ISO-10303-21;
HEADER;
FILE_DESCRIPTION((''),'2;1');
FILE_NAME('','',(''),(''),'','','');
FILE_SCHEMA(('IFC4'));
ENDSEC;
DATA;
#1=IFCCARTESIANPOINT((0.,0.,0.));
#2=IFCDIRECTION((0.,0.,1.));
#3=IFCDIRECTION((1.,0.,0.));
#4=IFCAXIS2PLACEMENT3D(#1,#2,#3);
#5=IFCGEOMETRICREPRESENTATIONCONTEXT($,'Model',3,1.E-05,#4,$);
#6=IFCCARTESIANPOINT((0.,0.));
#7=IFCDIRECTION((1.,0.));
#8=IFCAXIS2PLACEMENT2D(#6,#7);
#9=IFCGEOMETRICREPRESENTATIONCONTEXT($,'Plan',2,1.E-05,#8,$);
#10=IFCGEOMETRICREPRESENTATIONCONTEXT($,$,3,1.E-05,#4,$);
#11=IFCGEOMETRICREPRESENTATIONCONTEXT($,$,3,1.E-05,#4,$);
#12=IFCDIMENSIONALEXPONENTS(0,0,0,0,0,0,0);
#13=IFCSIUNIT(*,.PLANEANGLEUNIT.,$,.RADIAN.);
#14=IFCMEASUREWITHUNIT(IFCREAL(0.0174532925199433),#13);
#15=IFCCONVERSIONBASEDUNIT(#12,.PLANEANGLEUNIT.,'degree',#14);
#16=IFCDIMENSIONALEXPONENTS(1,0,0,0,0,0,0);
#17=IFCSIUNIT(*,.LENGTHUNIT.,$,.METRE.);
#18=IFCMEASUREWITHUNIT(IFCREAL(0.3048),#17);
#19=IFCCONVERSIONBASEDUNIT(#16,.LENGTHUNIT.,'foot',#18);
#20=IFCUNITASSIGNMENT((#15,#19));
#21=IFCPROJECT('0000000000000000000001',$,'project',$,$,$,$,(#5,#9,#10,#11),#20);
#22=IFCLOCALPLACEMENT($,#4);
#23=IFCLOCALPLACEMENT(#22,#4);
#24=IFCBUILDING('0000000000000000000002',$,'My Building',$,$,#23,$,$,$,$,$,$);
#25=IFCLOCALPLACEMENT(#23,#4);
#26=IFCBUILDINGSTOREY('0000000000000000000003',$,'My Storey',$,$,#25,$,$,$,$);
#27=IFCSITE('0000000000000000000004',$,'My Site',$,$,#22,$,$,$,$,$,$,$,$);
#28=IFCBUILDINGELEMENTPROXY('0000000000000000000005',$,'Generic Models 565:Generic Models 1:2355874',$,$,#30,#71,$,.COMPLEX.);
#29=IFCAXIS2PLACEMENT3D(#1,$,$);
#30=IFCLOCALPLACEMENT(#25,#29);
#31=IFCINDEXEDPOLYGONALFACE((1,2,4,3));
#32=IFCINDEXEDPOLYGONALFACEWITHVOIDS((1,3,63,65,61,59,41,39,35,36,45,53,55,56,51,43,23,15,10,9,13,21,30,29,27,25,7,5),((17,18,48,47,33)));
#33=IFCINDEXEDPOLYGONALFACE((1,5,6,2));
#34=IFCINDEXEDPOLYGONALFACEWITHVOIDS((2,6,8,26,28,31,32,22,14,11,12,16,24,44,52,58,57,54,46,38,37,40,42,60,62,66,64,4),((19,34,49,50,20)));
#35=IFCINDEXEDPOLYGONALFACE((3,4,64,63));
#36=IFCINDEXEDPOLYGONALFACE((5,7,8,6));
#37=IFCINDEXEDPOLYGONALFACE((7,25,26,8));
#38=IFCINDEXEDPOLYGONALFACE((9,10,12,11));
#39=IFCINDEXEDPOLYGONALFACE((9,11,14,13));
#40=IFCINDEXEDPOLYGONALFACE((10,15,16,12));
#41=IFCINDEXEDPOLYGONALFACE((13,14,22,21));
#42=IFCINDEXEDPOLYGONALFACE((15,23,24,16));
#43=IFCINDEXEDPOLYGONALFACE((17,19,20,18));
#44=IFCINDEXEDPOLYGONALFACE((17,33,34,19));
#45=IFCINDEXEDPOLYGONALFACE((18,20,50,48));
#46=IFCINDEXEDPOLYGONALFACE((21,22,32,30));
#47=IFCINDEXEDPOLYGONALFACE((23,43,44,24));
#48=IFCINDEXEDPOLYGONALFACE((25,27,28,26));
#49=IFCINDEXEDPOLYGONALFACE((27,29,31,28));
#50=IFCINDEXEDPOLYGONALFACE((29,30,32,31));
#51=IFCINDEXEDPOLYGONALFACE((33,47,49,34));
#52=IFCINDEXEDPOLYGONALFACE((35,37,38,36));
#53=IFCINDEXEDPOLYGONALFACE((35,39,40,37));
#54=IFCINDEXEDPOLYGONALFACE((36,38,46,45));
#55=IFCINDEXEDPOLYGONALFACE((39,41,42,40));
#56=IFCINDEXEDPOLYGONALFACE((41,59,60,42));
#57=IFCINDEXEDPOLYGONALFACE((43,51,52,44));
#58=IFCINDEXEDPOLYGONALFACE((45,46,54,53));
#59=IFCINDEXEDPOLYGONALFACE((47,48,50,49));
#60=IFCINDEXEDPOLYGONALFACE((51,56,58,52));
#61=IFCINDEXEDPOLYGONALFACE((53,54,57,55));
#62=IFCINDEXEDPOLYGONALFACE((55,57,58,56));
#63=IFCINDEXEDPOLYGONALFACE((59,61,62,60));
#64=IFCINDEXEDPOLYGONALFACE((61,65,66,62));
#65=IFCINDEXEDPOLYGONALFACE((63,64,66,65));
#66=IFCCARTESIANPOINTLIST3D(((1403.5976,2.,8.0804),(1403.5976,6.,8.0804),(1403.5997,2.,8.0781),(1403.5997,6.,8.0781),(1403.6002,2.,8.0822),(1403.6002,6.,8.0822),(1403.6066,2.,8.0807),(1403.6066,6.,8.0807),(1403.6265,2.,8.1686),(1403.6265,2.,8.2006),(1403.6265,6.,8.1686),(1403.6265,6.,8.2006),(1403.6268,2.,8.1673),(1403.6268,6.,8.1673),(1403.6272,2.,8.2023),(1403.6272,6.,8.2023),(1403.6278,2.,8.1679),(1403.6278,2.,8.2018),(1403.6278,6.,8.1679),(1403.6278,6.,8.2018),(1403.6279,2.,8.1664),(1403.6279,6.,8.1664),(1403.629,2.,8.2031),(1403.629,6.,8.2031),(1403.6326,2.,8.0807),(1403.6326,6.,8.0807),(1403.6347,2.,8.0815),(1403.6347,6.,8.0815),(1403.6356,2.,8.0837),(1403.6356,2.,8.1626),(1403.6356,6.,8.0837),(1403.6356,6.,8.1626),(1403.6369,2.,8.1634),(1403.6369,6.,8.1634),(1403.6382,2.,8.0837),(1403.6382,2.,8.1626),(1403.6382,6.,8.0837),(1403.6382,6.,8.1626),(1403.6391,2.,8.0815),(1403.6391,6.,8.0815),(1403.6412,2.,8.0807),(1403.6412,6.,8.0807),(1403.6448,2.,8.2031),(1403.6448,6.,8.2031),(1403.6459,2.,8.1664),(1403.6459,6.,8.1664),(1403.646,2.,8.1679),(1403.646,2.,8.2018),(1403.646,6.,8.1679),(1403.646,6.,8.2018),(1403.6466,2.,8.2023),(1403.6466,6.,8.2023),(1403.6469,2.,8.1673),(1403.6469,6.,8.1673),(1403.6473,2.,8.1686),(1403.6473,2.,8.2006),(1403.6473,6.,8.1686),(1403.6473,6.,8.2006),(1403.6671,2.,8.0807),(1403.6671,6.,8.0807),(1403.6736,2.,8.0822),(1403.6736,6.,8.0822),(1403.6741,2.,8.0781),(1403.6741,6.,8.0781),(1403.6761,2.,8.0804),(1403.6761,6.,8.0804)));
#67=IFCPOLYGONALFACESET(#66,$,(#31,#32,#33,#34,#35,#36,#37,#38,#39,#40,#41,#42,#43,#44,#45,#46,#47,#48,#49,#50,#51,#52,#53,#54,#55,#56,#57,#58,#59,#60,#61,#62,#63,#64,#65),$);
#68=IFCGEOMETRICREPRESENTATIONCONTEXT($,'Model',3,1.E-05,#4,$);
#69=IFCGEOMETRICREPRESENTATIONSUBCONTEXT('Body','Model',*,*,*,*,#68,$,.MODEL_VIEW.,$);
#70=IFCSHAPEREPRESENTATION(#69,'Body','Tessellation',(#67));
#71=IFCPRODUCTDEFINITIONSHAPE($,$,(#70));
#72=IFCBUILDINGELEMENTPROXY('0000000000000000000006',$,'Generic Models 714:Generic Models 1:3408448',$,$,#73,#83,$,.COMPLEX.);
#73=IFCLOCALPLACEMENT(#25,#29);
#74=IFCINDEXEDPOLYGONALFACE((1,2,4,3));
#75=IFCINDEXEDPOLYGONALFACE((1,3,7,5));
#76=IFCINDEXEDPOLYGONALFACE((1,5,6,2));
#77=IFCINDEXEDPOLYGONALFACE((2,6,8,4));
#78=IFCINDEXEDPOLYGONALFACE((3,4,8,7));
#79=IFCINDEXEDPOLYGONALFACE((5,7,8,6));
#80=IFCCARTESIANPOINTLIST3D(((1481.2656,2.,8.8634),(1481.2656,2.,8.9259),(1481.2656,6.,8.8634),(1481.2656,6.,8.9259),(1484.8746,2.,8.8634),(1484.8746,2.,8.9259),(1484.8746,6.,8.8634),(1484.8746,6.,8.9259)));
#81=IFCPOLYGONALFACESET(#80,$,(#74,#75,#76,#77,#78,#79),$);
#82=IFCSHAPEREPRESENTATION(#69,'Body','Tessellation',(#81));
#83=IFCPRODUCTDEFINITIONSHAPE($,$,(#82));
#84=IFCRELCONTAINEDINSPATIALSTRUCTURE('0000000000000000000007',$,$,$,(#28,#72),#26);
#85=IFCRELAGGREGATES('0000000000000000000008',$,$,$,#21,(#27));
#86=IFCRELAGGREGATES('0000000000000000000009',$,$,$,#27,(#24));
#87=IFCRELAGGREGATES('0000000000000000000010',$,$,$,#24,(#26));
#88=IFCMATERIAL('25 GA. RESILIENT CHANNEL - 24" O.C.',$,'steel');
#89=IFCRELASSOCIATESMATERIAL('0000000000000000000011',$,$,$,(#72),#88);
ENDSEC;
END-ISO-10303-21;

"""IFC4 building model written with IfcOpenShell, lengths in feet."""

from ifc_helpers import new_model, entity, si_unit, converted_unit, frame, origin_with_axes, origin_2d_with_axis, place, context, subcontext, project, spatial, polyline, line, indexed_curve, outline, extrude, material, element, save


model = new_model("IFC4")

# Units and contexts
model_context_1 = context("Model", 3, precision=1e-05, world=origin_with_axes())
plan_context = context("Plan", 2, precision=1e-05, world=origin_2d_with_axis())
model_context_2 = context("Model", 3, precision=1e-05, world=origin_with_axes())
context_of_model_1 = context(None, 3, precision=1e-05, world=origin_with_axes())
context_of_model_2 = context(None, 3, precision=1e-05, world=origin_with_axes())
body_context_1 = subcontext(model_context_2, "Body", "Model", "MODEL_VIEW")
ifc_project = project(units=[converted_unit("PLANEANGLEUNIT", "degree", entity("IfcReal", 0.0174532925199433), si_unit("PLANEANGLEUNIT", "RADIAN"), dimensions=[0, 0, 0, 0, 0, 0, 0]), converted_unit("LENGTHUNIT", "foot", entity("IfcReal", 0.3048), si_unit("LENGTHUNIT", "METRE"), dimensions=[1, 0, 0, 0, 0, 0, 0])], contexts=[model_context_1, plan_context, context_of_model_1, context_of_model_2])

# Site, building, storey
site_placement = place(None, origin_with_axes())
site = spatial("IfcSite", under=ifc_project, at=site_placement, Name="My Site")
building_placement = place(site_placement, origin_with_axes())
building = spatial("IfcBuilding", under=site, at=building_placement, Name="My Building")
storey_placement = place(building_placement, origin_with_axes())
storey = spatial("IfcBuildingStorey", under=building, at=storey_placement, Name="My Storey")

# Building element proxy
proxy_1_placement = place(storey_placement, frame((1403.5976, 6.0, 8.0781), z_axis=(0.0, -1.0, 0.0), x_axis=(0.0, 0.0, 1.0)))
element("IfcBuildingElementProxy", 1, at=proxy_1_placement, inside=storey, Name="Generic Models 565:Generic Models 1:2355874", PredefinedType="COMPLEX", context=body_context_1, shape_type="SweptSolid", body=[
    extrude(outline(indexed_curve([(0.0297, 0.0058), (0.0311, 0.006), (0.0627, 0.0015), (0.0643, 0.0005), (0.0648, -0.0014), (0.0625, -0.017), (0.0615, -0.0187), (0.0597, -0.0192), (0.0281, -0.0146), (0.0268, -0.014), (0.0261, -0.0129), (0.0234, -0.0047), (-0.0547, 0.0066), (-0.0569, 0.006), (-0.0581, 0.0041), (-0.0618, -0.0216), (-0.0612, -0.0282), (-0.0634, -0.0305), (-0.0654, -0.0281), (-0.0547, 0.0455), (-0.0522, 0.0472), (-0.0507, 0.0444), (-0.0532, 0.0382), (-0.0569, 0.0126), (-0.0563, 0.0103), (-0.0543, 0.0092), (0.0238, -0.0021), (0.0286, 0.005), (0.0301, 0.0048), (0.0637, 0.0), (0.0611, -0.018), (0.0275, -0.0132), (0.0244, -0.0035)], segments=[line(7, 6), line(6, 5), line(5, 4), line(4, 3), line(3, 2), line(2, 1), line(1, 28), line(28, 27), line(27, 26), line(26, 25), line(25, 24), line(24, 23), line(23, 22), line(22, 21), line(21, 20), line(20, 19), line(19, 18), line(18, 17), line(17, 16), line(16, 15), line(15, 14), line(14, 13), line(13, 12), line(12, 11), line(11, 10), line(10, 9), line(9, 8), line(8, 7)], self_intersect=False), holes=[indexed_curve([(0.0297, 0.0058), (0.0311, 0.006), (0.0627, 0.0015), (0.0643, 0.0005), (0.0648, -0.0014), (0.0625, -0.017), (0.0615, -0.0187), (0.0597, -0.0192), (0.0281, -0.0146), (0.0268, -0.014), (0.0261, -0.0129), (0.0234, -0.0047), (-0.0547, 0.0066), (-0.0569, 0.006), (-0.0581, 0.0041), (-0.0618, -0.0216), (-0.0612, -0.0282), (-0.0634, -0.0305), (-0.0654, -0.0281), (-0.0547, 0.0455), (-0.0522, 0.0472), (-0.0507, 0.0444), (-0.0532, 0.0382), (-0.0569, 0.0126), (-0.0563, 0.0103), (-0.0543, 0.0092), (0.0238, -0.0021), (0.0286, 0.005), (0.0301, 0.0048), (0.0637, 0.0), (0.0611, -0.018), (0.0275, -0.0132), (0.0244, -0.0035)], segments=[line(31, 32), line(32, 33), line(33, 29), line(29, 30), line(30, 31)], self_intersect=False)]), frame((0.0607, -0.0392, 0.0), z_axis=(0.0, 0.0, -1.0), x_axis=(0.989698, -0.14317, 0.0)), (0.0, 0.0, -1.0), 4.0),
])

# Building element proxy
ifc_material_1 = material(Name="25 GA. RESILIENT CHANNEL - 24\" O.C.", Category="steel")
proxy_2_placement = place(storey_placement, frame((1481.263, 6.0, 8.8634), z_axis=(0.0, -1.0, 0.0), x_axis=(0.0, 0.0, 1.0)))
element("IfcBuildingElementProxy", 2, at=proxy_2_placement, inside=storey, material=ifc_material_1, Name="Generic Models 714:Generic Models 1:3408448", PredefinedType="COMPLEX", context=body_context_1, shape_type="SweptSolid", body=[
    extrude(outline(polyline([(-0.0313, -1.8045), (0.0312, -1.8045), (0.0313, 1.8045), (-0.0312, 1.8045), (-0.0313, -1.8045)])), frame((0.0313, -1.8072, 0.0), z_axis=(0.0, 0.0, -1.0), x_axis=(-1.0, 0.0, 0.0)), (0.0, 0.0, -1.0), 4.0),
])

save(model, "model.ifc")
